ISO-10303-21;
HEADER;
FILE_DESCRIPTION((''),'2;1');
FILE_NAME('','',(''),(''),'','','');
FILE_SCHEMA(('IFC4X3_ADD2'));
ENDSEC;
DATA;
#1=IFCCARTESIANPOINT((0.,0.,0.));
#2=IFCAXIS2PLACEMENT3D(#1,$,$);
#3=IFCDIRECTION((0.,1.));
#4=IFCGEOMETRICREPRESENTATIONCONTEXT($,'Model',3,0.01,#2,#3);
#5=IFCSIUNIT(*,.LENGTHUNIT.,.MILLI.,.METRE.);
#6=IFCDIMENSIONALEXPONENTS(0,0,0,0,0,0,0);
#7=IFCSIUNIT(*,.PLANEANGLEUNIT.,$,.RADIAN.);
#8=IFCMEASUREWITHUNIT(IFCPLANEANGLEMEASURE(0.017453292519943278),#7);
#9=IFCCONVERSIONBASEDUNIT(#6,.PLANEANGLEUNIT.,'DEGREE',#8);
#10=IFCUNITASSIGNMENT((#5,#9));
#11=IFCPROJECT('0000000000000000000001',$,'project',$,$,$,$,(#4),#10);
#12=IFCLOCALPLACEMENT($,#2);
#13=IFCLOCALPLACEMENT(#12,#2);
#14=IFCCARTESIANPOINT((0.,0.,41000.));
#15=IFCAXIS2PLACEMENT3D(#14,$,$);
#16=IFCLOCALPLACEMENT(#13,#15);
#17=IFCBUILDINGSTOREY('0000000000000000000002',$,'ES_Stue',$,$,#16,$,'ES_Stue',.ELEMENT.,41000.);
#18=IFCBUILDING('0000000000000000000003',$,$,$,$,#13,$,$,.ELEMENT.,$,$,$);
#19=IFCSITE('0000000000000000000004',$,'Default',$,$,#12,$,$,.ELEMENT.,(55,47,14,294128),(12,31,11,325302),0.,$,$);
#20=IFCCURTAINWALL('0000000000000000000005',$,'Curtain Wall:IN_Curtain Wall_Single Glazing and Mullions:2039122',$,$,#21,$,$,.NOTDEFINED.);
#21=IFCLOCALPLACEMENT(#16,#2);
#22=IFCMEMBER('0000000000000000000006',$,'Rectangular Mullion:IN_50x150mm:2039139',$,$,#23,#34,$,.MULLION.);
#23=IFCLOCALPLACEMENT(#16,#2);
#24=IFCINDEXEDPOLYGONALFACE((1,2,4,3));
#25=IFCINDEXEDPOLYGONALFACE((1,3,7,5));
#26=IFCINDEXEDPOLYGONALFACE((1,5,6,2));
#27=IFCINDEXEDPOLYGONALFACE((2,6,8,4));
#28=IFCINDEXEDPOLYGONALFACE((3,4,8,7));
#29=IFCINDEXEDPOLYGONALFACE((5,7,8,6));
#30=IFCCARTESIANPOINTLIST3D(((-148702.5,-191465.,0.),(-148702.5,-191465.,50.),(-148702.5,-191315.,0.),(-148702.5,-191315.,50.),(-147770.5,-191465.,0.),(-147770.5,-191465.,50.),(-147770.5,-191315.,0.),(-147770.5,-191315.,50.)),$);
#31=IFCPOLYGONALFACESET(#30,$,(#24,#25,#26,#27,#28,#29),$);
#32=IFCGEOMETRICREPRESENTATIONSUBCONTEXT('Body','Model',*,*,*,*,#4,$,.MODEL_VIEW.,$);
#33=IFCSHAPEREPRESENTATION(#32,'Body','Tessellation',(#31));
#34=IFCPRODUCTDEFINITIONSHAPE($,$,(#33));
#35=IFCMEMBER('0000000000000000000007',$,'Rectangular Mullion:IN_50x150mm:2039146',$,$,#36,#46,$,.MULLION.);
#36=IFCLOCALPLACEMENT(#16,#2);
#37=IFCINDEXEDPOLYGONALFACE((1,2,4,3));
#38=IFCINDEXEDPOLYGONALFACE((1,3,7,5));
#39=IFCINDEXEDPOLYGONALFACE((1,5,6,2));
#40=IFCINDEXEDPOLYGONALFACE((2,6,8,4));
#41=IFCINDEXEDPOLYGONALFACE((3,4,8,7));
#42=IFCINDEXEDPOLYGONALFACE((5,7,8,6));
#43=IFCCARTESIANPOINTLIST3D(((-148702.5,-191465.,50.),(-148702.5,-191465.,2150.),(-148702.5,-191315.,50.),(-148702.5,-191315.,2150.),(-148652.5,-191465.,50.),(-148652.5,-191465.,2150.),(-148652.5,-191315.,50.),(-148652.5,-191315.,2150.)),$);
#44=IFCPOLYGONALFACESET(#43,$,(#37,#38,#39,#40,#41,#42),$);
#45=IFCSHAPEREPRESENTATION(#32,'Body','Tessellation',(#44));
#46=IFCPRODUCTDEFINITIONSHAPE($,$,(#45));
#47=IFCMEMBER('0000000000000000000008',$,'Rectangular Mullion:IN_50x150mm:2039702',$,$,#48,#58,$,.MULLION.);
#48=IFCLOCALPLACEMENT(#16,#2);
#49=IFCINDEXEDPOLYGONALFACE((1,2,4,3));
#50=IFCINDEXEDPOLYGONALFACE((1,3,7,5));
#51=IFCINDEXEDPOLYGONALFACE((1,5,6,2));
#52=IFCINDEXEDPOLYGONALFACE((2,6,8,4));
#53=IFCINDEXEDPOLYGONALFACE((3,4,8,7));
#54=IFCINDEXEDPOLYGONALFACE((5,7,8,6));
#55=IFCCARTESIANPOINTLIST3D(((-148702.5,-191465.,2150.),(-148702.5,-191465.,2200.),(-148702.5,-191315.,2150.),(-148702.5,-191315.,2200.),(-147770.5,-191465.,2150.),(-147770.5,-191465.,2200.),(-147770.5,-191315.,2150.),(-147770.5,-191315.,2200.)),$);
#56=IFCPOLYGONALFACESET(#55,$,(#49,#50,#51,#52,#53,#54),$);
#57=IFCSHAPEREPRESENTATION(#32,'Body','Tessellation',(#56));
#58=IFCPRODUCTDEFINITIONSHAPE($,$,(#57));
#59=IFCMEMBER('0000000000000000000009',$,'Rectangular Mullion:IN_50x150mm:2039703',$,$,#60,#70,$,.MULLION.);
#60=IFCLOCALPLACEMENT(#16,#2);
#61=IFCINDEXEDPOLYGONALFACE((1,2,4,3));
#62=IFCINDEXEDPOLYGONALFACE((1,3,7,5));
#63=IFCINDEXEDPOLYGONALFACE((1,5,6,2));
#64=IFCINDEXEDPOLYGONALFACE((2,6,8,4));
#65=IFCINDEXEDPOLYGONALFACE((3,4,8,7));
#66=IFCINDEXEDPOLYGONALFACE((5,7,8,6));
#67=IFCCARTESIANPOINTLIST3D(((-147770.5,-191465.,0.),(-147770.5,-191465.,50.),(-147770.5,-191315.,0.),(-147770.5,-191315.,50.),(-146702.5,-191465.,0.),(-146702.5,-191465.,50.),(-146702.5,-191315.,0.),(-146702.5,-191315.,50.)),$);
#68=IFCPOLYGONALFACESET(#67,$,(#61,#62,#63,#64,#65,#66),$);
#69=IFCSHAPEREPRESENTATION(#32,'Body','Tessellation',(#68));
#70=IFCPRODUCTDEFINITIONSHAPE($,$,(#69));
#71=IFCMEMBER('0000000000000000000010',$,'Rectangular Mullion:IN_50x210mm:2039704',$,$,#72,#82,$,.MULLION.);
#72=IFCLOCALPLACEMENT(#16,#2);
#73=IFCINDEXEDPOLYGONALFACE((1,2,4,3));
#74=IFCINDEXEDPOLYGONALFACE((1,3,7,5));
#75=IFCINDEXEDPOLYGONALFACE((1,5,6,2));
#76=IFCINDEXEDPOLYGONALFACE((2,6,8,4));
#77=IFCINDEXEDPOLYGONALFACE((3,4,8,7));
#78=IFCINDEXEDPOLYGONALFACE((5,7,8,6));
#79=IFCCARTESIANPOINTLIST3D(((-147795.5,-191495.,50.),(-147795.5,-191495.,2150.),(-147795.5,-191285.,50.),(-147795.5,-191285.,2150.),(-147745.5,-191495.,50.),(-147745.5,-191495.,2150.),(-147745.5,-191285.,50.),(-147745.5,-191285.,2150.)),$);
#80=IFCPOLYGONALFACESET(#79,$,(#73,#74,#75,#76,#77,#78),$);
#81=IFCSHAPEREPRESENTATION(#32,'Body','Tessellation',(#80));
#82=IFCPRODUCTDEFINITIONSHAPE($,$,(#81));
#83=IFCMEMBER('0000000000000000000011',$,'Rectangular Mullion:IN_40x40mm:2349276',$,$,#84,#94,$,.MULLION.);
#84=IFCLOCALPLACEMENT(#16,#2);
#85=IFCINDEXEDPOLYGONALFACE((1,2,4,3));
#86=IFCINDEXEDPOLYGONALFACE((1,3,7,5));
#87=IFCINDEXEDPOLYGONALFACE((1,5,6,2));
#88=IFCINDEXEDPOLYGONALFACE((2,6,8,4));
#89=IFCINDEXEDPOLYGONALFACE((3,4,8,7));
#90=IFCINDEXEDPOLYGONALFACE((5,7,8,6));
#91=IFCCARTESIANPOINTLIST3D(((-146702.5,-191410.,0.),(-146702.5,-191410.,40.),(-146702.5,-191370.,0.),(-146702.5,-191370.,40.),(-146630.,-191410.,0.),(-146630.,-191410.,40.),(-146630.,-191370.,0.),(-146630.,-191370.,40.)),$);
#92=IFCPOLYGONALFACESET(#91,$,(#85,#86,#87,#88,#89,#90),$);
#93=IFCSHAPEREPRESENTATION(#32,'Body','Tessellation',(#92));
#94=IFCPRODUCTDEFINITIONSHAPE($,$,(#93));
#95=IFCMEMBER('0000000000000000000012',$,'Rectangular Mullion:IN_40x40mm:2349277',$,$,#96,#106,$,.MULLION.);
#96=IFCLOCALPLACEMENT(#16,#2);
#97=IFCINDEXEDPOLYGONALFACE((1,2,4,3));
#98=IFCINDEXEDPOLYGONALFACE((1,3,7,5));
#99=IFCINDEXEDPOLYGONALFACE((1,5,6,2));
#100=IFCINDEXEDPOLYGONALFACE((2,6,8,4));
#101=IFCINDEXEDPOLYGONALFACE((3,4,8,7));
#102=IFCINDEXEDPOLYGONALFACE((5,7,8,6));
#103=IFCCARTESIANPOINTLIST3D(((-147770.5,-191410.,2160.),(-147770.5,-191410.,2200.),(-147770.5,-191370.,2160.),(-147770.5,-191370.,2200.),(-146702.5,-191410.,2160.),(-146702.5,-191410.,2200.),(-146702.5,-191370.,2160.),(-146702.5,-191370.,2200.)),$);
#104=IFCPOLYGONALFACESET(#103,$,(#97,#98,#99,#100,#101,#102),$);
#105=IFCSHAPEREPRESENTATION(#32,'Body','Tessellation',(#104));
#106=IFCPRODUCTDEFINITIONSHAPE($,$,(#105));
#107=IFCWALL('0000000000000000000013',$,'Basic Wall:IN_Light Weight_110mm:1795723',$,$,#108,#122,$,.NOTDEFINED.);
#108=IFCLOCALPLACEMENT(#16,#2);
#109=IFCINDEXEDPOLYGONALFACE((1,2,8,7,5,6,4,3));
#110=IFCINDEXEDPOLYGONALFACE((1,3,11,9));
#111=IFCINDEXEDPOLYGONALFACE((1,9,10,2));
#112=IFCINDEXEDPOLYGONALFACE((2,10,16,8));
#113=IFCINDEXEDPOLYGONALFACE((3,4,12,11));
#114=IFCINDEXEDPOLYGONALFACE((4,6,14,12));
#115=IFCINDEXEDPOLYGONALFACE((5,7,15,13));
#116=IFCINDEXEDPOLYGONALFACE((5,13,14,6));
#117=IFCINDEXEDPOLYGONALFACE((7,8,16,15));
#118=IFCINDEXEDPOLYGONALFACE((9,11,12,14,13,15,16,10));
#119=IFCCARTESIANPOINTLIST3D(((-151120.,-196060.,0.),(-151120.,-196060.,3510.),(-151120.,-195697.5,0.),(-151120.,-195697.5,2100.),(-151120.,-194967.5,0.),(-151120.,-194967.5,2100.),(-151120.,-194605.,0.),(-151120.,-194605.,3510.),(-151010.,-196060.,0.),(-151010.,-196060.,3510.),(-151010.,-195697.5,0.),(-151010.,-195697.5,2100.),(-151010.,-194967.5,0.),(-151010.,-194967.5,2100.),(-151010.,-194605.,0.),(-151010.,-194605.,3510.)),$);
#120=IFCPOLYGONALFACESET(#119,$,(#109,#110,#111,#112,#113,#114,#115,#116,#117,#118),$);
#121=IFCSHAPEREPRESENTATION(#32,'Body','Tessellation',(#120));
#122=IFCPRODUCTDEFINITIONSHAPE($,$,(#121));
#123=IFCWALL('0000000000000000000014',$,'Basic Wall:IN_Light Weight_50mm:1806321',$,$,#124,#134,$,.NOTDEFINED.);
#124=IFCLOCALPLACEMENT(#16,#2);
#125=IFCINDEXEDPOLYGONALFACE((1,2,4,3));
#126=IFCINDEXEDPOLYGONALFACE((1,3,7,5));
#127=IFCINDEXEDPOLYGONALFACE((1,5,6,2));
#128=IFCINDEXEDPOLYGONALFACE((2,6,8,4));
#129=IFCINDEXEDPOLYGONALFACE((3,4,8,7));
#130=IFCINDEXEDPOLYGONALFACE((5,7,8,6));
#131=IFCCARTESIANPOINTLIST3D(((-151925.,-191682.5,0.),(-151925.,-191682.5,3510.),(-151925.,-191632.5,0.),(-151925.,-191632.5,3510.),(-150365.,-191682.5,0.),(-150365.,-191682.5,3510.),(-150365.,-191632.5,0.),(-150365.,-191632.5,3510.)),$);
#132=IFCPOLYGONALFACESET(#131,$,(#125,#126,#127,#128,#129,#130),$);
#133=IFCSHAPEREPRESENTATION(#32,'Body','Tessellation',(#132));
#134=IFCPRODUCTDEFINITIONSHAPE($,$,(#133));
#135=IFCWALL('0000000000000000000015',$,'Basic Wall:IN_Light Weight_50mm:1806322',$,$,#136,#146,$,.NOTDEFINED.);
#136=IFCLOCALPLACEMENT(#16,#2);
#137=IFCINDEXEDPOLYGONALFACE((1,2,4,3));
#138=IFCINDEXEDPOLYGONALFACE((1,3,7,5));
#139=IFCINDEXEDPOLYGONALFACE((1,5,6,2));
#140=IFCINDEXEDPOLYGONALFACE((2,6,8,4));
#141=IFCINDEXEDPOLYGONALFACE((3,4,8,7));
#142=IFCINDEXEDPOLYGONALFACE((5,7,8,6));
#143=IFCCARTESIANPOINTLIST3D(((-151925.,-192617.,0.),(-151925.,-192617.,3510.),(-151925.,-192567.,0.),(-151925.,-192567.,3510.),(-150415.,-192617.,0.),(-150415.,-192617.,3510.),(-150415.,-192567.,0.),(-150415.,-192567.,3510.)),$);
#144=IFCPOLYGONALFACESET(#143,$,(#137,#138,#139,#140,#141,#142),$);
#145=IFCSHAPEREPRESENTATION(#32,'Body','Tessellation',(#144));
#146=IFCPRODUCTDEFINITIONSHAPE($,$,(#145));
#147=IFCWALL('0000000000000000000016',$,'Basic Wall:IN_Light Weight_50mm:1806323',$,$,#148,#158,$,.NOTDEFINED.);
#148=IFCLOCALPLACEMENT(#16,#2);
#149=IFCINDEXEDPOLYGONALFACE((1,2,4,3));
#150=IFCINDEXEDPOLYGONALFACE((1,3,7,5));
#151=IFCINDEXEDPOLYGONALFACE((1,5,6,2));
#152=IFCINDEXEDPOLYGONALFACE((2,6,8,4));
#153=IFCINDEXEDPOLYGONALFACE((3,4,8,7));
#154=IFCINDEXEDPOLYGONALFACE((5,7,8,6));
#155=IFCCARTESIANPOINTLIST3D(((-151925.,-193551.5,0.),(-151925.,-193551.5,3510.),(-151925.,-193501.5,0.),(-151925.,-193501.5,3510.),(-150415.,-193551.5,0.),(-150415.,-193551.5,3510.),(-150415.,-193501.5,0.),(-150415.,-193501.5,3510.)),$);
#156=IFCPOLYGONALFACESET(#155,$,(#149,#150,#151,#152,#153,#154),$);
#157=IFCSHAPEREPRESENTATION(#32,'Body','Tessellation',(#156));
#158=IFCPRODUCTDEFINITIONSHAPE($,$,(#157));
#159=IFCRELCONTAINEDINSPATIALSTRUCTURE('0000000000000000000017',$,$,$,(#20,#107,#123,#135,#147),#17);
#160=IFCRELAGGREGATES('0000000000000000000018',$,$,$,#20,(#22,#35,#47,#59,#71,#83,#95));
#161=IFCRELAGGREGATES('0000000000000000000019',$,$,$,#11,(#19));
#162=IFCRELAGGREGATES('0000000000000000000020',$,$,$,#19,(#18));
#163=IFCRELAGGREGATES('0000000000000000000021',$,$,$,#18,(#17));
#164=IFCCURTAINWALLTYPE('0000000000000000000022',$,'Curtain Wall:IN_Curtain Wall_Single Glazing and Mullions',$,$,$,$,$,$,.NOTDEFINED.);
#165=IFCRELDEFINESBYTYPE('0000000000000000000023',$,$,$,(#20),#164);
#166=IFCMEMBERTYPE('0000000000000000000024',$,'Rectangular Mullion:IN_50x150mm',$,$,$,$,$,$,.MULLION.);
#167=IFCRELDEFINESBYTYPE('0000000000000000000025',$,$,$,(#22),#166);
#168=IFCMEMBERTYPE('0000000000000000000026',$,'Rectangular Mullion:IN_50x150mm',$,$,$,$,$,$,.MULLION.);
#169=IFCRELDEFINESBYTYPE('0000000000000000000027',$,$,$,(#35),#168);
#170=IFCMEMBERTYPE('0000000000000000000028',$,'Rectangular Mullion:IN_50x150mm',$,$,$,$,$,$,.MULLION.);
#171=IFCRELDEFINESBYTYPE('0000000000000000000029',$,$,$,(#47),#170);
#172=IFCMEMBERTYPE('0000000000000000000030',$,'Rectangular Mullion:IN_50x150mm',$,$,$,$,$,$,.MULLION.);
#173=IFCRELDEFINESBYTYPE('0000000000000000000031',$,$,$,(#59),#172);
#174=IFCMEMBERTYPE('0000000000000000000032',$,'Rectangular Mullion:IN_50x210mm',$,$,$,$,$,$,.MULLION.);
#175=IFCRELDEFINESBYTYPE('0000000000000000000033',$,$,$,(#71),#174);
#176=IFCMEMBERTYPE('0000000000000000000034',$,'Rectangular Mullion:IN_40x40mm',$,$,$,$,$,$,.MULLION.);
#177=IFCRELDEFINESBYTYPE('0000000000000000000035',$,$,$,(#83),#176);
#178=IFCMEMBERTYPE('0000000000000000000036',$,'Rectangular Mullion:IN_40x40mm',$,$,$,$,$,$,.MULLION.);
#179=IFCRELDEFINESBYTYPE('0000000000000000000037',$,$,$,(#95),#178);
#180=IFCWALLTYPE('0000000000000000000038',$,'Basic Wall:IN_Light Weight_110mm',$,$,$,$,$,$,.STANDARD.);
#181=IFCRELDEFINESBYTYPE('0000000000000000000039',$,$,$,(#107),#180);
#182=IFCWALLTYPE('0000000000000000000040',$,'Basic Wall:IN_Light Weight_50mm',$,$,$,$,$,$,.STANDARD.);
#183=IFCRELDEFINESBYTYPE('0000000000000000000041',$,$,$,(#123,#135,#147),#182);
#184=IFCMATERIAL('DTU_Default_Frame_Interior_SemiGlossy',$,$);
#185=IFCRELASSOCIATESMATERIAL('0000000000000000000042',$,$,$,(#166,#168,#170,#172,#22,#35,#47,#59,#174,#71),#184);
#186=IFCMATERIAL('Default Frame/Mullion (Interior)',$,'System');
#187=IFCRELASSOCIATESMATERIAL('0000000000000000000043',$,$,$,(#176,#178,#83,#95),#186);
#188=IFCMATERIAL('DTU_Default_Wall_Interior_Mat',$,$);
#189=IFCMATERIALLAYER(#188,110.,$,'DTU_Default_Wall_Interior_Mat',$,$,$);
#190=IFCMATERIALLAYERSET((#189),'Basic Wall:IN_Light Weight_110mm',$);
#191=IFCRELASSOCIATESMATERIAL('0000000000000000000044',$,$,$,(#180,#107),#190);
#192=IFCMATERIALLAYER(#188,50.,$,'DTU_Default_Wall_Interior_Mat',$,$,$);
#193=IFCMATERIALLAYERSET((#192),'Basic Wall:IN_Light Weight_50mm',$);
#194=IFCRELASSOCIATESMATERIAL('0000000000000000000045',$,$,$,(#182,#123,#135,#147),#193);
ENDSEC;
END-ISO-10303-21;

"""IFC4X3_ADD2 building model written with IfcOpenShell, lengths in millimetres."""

from ifc_helpers import new_model, entity, si_unit, converted_unit, direction, frame, frame_2d, origin, origin_2d_with_axis, place, context, subcontext, project, spatial, rectangle, extrude, source, transform, mapped, material, layer, layer_set, material_profile, profile_set, profile_usage, type_object, type_shapes, element, aggregate, save


model = new_model("IFC4X3_ADD2")

# Units and contexts
model_context = context("Model", 3, precision=0.01, world=origin(), true_north=direction((0.0, 1.0)))
body_context = subcontext(model_context, "Body", "Model", "MODEL_VIEW")
ifc_project = project(units=[si_unit("LENGTHUNIT", "METRE", prefix="MILLI"), converted_unit("PLANEANGLEUNIT", "DEGREE", entity("IfcPlaneAngleMeasure", 0.017453292519943278), si_unit("PLANEANGLEUNIT", "RADIAN"), dimensions=[0, 0, 0, 0, 0, 0, 0])], contexts=[model_context])

# Site, building, storey
site_placement = place(None, origin())
site = spatial("IfcSite", under=ifc_project, at=site_placement, Name="Default", CompositionType="ELEMENT", RefLatitude=(55, 47, 14, 294128), RefLongitude=(12, 31, 11, 325302), RefElevation=0.0)
building_placement = place(site_placement, origin())
building = spatial("IfcBuilding", under=site, at=building_placement, CompositionType="ELEMENT")
storey_placement = place(building_placement, frame((0.0, 0.0, 41000.0)))
storey = spatial("IfcBuildingStorey", under=building, at=storey_placement, Name="ES_Stue", LongName="ES_Stue", CompositionType="ELEMENT", Elevation=41000.0)

# Curtain wall, members
curtain_wall_type = type_object("IfcCurtainWallType", Name="Curtain Wall:IN_Curtain Wall_Single Glazing and Mullions", PredefinedType="NOTDEFINED")
curtain_wall_placement = place(storey_placement, frame((0.0, 0.0, -41000.0)))
curtain_wall = element("IfcCurtainWall", 1, at=curtain_wall_placement, inside=storey, type_object=curtain_wall_type, Name="Curtain Wall:IN_Curtain Wall_Single Glazing and Mullions:2039122", PredefinedType="NOTDEFINED")
ifc_material_1 = material(Name="DTU_Default_Frame_Interior_SemiGlossy")
ifc_material_profile_1 = material_profile(ifc_material_1, rectangle(XDim=50.0, YDim=150.0, at=origin_2d_with_axis()), Name="IN_50x150mm")
ifc_profile_set_1 = profile_set([ifc_material_profile_1], Name="IN_50x150mm")
ifc_profile_usage_1 = profile_usage(ifc_profile_set_1)
member_type_1 = type_object("IfcMemberType", Name="Rectangular Mullion:IN_50x150mm", PredefinedType="MULLION", material=ifc_profile_set_1)
shared_shape_1 = source(origin(), body_context, "Body", "SweptSolid", [
    extrude(rectangle(XDim=50.0, YDim=150.0, at=origin_2d_with_axis()), frame((-25.0, 0.0, -932.0), z_axis=(0.0, 0.0, 1.0), x_axis=(-1.0, 0.0, 0.0)), (0.0, 0.0, 1.0), 932.0),
])
type_shapes(member_type_1, [shared_shape_1])
member_1_placement = place(curtain_wall_placement, frame((-148702.5, -191390.0, 41000.0), z_axis=(-1.0, 0.0, 0.0), x_axis=(0.0, 0.0, -1.0)))
member_1 = element("IfcMember", 2, at=member_1_placement, type_object=member_type_1, material=ifc_profile_usage_1, Name="Rectangular Mullion:IN_50x150mm:2039139", PredefinedType="MULLION", context=body_context, shape_type="MappedRepresentation", body=[
    mapped(shared_shape_1, transform((0.0, 0.0, 0.0), scale=1.0)),
])
member_type_2 = type_object("IfcMemberType", Name="Rectangular Mullion:IN_50x150mm", PredefinedType="MULLION", material=ifc_profile_set_1)
shared_shape_2 = source(origin(), body_context, "Body", "SweptSolid", [
    extrude(rectangle(XDim=50.0, YDim=150.0, at=origin_2d_with_axis()), frame((-25.0, 0.0, -2100.0), z_axis=(0.0, 0.0, 1.0), x_axis=(-1.0, 0.0, 0.0)), (0.0, 0.0, 1.0), 2100.0),
])
type_shapes(member_type_2, [shared_shape_2])
member_2_placement = place(curtain_wall_placement, frame((-148702.5, -191390.0, 43150.0), z_axis=(0.0, 0.0, 1.0), x_axis=(-1.0, 0.0, 0.0)))
member_2 = element("IfcMember", 3, at=member_2_placement, type_object=member_type_2, material=ifc_profile_usage_1, Name="Rectangular Mullion:IN_50x150mm:2039146", PredefinedType="MULLION", context=body_context, shape_type="MappedRepresentation", body=[
    mapped(shared_shape_2, transform((0.0, 0.0, 0.0), scale=1.0)),
])
member_type_3 = type_object("IfcMemberType", Name="Rectangular Mullion:IN_50x150mm", PredefinedType="MULLION", material=ifc_profile_set_1)
shared_shape_3 = source(origin(), body_context, "Body", "SweptSolid", [
    extrude(rectangle(XDim=50.0, YDim=150.0, at=origin_2d_with_axis()), frame((-25.0, 0.0, -932.0), z_axis=(0.0, 0.0, 1.0), x_axis=(-1.0, 0.0, 0.0)), (0.0, 0.0, 1.0), 932.0),
])
type_shapes(member_type_3, [shared_shape_3])
member_3_placement = place(curtain_wall_placement, frame((-147770.5, -191390.0, 43200.0), z_axis=(1.0, 0.0, 0.0), x_axis=(0.0, 0.0, 1.0)))
member_3 = element("IfcMember", 4, at=member_3_placement, type_object=member_type_3, material=ifc_profile_usage_1, Name="Rectangular Mullion:IN_50x150mm:2039702", PredefinedType="MULLION", context=body_context, shape_type="MappedRepresentation", body=[
    mapped(shared_shape_3, transform((0.0, 0.0, 0.0), scale=1.0)),
])
member_type_4 = type_object("IfcMemberType", Name="Rectangular Mullion:IN_50x150mm", PredefinedType="MULLION", material=ifc_profile_set_1)
shared_shape_4 = source(origin(), body_context, "Body", "SweptSolid", [
    extrude(rectangle(XDim=50.0, YDim=150.0, at=origin_2d_with_axis()), frame((-25.0, 0.0, -1068.0), z_axis=(0.0, 0.0, 1.0), x_axis=(-1.0, 0.0, 0.0)), (0.0, 0.0, 1.0), 1068.0),
])
type_shapes(member_type_4, [shared_shape_4])
member_4_placement = place(curtain_wall_placement, frame((-147770.5, -191390.0, 41000.0), z_axis=(-1.0, 0.0, 0.0), x_axis=(0.0, 0.0, -1.0)))
member_4 = element("IfcMember", 5, at=member_4_placement, type_object=member_type_4, material=ifc_profile_usage_1, Name="Rectangular Mullion:IN_50x150mm:2039703", PredefinedType="MULLION", context=body_context, shape_type="MappedRepresentation", body=[
    mapped(shared_shape_4, transform((0.0, 0.0, 0.0), scale=1.0)),
])
ifc_material_profile_2 = material_profile(ifc_material_1, rectangle(XDim=50.0, YDim=210.0, at=origin_2d_with_axis()), Name="IN_50x210mm")
ifc_profile_set_2 = profile_set([ifc_material_profile_2], Name="IN_50x210mm")
ifc_profile_usage_2 = profile_usage(ifc_profile_set_2)
member_type_5 = type_object("IfcMemberType", Name="Rectangular Mullion:IN_50x210mm", PredefinedType="MULLION", material=ifc_profile_set_2)
shared_shape_5 = source(origin(), body_context, "Body", "SweptSolid", [
    extrude(rectangle(XDim=50.0, YDim=210.0, at=origin_2d_with_axis()), frame((0.0, 0.0, -2100.0), z_axis=(0.0, 0.0, 1.0), x_axis=(-1.0, 0.0, 0.0)), (0.0, 0.0, 1.0), 2100.0),
])
type_shapes(member_type_5, [shared_shape_5])
member_5_placement = place(curtain_wall_placement, frame((-147770.5, -191390.0, 41050.0), z_axis=(0.0, 0.0, -1.0), x_axis=(1.0, 0.0, 0.0)))
member_5 = element("IfcMember", 6, at=member_5_placement, type_object=member_type_5, material=ifc_profile_usage_2, Name="Rectangular Mullion:IN_50x210mm:2039704", PredefinedType="MULLION", context=body_context, shape_type="MappedRepresentation", body=[
    mapped(shared_shape_5, transform((0.0, 0.0, 0.0), scale=1.0)),
])
ifc_material_2 = material(Name="Default Frame/Mullion (Interior)", Category="System")
ifc_material_profile_3 = material_profile(ifc_material_2, rectangle(XDim=40.0, YDim=40.0, at=frame_2d((0.0, 0.0), x_axis=(1.0, 0.0))), Name="IN_40x40mm")
ifc_profile_set_3 = profile_set([ifc_material_profile_3], Name="IN_40x40mm")
ifc_profile_usage_3 = profile_usage(ifc_profile_set_3)
member_type_6 = type_object("IfcMemberType", Name="Rectangular Mullion:IN_40x40mm", PredefinedType="MULLION", material=ifc_profile_set_3)
shared_shape_6 = source(origin(), body_context, "Body", "SweptSolid", [
    extrude(rectangle(XDim=40.0, YDim=40.0, at=frame_2d((0.0, 0.0), x_axis=(1.0, 0.0))), frame((-20.0, 0.0, -72.5), z_axis=(0.0, 0.0, 1.0), x_axis=(-1.0, 0.0, 0.0)), (0.0, 0.0, 1.0), 72.5),
])
type_shapes(member_type_6, [shared_shape_6])
member_6_placement = place(curtain_wall_placement, frame((-146702.5, -191390.0, 41000.0), z_axis=(-1.0, 0.0, 0.0), x_axis=(0.0, 0.0, -1.0)))
member_6 = element("IfcMember", 7, at=member_6_placement, type_object=member_type_6, material=ifc_profile_usage_3, Name="Rectangular Mullion:IN_40x40mm:2349276", PredefinedType="MULLION", context=body_context, shape_type="MappedRepresentation", body=[
    mapped(shared_shape_6, transform((0.0, 0.0, 0.0), scale=1.0)),
])
member_type_7 = type_object("IfcMemberType", Name="Rectangular Mullion:IN_40x40mm", PredefinedType="MULLION", material=ifc_profile_set_3)
shared_shape_7 = source(origin(), body_context, "Body", "SweptSolid", [
    extrude(rectangle(XDim=40.0, YDim=40.0, at=frame_2d((0.0, 0.0), x_axis=(1.0, 0.0))), frame((-20.0, 0.0, -1068.0), z_axis=(0.0, 0.0, 1.0), x_axis=(-1.0, 0.0, 0.0)), (0.0, 0.0, 1.0), 1068.0),
])
type_shapes(member_type_7, [shared_shape_7])
member_7_placement = place(curtain_wall_placement, frame((-146702.5, -191390.0, 43200.0), z_axis=(1.0, 0.0, 0.0), x_axis=(0.0, 0.0, 1.0)))
member_7 = element("IfcMember", 8, at=member_7_placement, type_object=member_type_7, material=ifc_profile_usage_3, Name="Rectangular Mullion:IN_40x40mm:2349277", PredefinedType="MULLION", context=body_context, shape_type="MappedRepresentation", body=[
    mapped(shared_shape_7, transform((0.0, 0.0, 0.0), scale=1.0)),
])
aggregate(curtain_wall, [member_1, member_2, member_3, member_4, member_5, member_6, member_7])

# Wall, opening
ifc_material_3 = material(Name="DTU_Default_Wall_Interior_Mat")
ifc_layer_1 = layer(ifc_material_3, 110.0, Name="DTU_Default_Wall_Interior_Mat")
ifc_layer_set_1 = layer_set([ifc_layer_1], Name="Basic Wall:IN_Light Weight_110mm")
wall_type_1 = type_object("IfcWallType", Name="Basic Wall:IN_Light Weight_110mm", PredefinedType="STANDARD", material=ifc_layer_set_1)
wall_1_placement = place(storey_placement, frame((-151065.0, -194605.0, 0.0), z_axis=(0.0, 0.0, 1.0), x_axis=(0.0, -1.0, 0.0)))
wall_1 = element("IfcWall", 9, at=wall_1_placement, inside=storey, type_object=wall_type_1, material=ifc_layer_set_1, Name="Basic Wall:IN_Light Weight_110mm:1795723", PredefinedType="NOTDEFINED", context=body_context, shape_type="SweptSolid", body=[
    extrude(rectangle(XDim=1455.0, YDim=110.0, at=frame_2d((727.5, 0.0), x_axis=(-1.0, 0.0))), origin(), (0.0, 0.0, 1.0), 3510.0),
])
opening_1_placement = place(wall_1_placement, frame((1092.5, 55.0, 0.0)))
element("IfcOpeningElement", 10, at=opening_1_placement, cuts=wall_1, PredefinedType="OPENING", context=body_context, shape_type="SweptSolid", body=[
    extrude(rectangle(XDim=2100.0, YDim=730.0, at=frame_2d((1050.0, 365.0), x_axis=(1.0, 0.0))), frame((0.0, 0.0, 0.0), z_axis=(0.0, -1.0, 0.0), x_axis=(0.0, 0.0, 1.0)), (0.0, 0.0, 1.0), 110.0),
])

# Walls
ifc_layer_2 = layer(ifc_material_3, 50.0, Name="DTU_Default_Wall_Interior_Mat")
ifc_layer_set_2 = layer_set([ifc_layer_2], Name="Basic Wall:IN_Light Weight_50mm")
wall_type_2 = type_object("IfcWallType", Name="Basic Wall:IN_Light Weight_50mm", PredefinedType="STANDARD", material=ifc_layer_set_2)
wall_2_placement = place(storey_placement, frame((-151925.0, -191657.5, 0.0)))
element("IfcWall", 11, at=wall_2_placement, inside=storey, type_object=wall_type_2, material=ifc_layer_set_2, Name="Basic Wall:IN_Light Weight_50mm:1806321", PredefinedType="NOTDEFINED", context=body_context, shape_type="SweptSolid", body=[
    extrude(rectangle(XDim=1560.0, YDim=50.0, at=frame_2d((780.0, 0.0), x_axis=(-1.0, 0.0))), origin(), (0.0, 0.0, 1.0), 3510.0),
])
for number, where, name in (
    (12, (-151925.0, -192592.0, 0.0), "Basic Wall:IN_Light Weight_50mm:1806322"),
    (13, (-151925.0, -193526.5, 0.0), "Basic Wall:IN_Light Weight_50mm:1806323"),
):
    element("IfcWall", number, at=place(storey_placement, frame(where)), inside=storey, type_object=wall_type_2, material=ifc_layer_set_2, Name=name, PredefinedType="NOTDEFINED", context=body_context, shape_type="SweptSolid", body=[
        extrude(rectangle(XDim=1510.0, YDim=50.0, at=frame_2d((755.0, 0.0), x_axis=(-1.0, 0.0))), origin(), (0.0, 0.0, 1.0), 3510.0),
    ])

save(model, "model.ifc")
